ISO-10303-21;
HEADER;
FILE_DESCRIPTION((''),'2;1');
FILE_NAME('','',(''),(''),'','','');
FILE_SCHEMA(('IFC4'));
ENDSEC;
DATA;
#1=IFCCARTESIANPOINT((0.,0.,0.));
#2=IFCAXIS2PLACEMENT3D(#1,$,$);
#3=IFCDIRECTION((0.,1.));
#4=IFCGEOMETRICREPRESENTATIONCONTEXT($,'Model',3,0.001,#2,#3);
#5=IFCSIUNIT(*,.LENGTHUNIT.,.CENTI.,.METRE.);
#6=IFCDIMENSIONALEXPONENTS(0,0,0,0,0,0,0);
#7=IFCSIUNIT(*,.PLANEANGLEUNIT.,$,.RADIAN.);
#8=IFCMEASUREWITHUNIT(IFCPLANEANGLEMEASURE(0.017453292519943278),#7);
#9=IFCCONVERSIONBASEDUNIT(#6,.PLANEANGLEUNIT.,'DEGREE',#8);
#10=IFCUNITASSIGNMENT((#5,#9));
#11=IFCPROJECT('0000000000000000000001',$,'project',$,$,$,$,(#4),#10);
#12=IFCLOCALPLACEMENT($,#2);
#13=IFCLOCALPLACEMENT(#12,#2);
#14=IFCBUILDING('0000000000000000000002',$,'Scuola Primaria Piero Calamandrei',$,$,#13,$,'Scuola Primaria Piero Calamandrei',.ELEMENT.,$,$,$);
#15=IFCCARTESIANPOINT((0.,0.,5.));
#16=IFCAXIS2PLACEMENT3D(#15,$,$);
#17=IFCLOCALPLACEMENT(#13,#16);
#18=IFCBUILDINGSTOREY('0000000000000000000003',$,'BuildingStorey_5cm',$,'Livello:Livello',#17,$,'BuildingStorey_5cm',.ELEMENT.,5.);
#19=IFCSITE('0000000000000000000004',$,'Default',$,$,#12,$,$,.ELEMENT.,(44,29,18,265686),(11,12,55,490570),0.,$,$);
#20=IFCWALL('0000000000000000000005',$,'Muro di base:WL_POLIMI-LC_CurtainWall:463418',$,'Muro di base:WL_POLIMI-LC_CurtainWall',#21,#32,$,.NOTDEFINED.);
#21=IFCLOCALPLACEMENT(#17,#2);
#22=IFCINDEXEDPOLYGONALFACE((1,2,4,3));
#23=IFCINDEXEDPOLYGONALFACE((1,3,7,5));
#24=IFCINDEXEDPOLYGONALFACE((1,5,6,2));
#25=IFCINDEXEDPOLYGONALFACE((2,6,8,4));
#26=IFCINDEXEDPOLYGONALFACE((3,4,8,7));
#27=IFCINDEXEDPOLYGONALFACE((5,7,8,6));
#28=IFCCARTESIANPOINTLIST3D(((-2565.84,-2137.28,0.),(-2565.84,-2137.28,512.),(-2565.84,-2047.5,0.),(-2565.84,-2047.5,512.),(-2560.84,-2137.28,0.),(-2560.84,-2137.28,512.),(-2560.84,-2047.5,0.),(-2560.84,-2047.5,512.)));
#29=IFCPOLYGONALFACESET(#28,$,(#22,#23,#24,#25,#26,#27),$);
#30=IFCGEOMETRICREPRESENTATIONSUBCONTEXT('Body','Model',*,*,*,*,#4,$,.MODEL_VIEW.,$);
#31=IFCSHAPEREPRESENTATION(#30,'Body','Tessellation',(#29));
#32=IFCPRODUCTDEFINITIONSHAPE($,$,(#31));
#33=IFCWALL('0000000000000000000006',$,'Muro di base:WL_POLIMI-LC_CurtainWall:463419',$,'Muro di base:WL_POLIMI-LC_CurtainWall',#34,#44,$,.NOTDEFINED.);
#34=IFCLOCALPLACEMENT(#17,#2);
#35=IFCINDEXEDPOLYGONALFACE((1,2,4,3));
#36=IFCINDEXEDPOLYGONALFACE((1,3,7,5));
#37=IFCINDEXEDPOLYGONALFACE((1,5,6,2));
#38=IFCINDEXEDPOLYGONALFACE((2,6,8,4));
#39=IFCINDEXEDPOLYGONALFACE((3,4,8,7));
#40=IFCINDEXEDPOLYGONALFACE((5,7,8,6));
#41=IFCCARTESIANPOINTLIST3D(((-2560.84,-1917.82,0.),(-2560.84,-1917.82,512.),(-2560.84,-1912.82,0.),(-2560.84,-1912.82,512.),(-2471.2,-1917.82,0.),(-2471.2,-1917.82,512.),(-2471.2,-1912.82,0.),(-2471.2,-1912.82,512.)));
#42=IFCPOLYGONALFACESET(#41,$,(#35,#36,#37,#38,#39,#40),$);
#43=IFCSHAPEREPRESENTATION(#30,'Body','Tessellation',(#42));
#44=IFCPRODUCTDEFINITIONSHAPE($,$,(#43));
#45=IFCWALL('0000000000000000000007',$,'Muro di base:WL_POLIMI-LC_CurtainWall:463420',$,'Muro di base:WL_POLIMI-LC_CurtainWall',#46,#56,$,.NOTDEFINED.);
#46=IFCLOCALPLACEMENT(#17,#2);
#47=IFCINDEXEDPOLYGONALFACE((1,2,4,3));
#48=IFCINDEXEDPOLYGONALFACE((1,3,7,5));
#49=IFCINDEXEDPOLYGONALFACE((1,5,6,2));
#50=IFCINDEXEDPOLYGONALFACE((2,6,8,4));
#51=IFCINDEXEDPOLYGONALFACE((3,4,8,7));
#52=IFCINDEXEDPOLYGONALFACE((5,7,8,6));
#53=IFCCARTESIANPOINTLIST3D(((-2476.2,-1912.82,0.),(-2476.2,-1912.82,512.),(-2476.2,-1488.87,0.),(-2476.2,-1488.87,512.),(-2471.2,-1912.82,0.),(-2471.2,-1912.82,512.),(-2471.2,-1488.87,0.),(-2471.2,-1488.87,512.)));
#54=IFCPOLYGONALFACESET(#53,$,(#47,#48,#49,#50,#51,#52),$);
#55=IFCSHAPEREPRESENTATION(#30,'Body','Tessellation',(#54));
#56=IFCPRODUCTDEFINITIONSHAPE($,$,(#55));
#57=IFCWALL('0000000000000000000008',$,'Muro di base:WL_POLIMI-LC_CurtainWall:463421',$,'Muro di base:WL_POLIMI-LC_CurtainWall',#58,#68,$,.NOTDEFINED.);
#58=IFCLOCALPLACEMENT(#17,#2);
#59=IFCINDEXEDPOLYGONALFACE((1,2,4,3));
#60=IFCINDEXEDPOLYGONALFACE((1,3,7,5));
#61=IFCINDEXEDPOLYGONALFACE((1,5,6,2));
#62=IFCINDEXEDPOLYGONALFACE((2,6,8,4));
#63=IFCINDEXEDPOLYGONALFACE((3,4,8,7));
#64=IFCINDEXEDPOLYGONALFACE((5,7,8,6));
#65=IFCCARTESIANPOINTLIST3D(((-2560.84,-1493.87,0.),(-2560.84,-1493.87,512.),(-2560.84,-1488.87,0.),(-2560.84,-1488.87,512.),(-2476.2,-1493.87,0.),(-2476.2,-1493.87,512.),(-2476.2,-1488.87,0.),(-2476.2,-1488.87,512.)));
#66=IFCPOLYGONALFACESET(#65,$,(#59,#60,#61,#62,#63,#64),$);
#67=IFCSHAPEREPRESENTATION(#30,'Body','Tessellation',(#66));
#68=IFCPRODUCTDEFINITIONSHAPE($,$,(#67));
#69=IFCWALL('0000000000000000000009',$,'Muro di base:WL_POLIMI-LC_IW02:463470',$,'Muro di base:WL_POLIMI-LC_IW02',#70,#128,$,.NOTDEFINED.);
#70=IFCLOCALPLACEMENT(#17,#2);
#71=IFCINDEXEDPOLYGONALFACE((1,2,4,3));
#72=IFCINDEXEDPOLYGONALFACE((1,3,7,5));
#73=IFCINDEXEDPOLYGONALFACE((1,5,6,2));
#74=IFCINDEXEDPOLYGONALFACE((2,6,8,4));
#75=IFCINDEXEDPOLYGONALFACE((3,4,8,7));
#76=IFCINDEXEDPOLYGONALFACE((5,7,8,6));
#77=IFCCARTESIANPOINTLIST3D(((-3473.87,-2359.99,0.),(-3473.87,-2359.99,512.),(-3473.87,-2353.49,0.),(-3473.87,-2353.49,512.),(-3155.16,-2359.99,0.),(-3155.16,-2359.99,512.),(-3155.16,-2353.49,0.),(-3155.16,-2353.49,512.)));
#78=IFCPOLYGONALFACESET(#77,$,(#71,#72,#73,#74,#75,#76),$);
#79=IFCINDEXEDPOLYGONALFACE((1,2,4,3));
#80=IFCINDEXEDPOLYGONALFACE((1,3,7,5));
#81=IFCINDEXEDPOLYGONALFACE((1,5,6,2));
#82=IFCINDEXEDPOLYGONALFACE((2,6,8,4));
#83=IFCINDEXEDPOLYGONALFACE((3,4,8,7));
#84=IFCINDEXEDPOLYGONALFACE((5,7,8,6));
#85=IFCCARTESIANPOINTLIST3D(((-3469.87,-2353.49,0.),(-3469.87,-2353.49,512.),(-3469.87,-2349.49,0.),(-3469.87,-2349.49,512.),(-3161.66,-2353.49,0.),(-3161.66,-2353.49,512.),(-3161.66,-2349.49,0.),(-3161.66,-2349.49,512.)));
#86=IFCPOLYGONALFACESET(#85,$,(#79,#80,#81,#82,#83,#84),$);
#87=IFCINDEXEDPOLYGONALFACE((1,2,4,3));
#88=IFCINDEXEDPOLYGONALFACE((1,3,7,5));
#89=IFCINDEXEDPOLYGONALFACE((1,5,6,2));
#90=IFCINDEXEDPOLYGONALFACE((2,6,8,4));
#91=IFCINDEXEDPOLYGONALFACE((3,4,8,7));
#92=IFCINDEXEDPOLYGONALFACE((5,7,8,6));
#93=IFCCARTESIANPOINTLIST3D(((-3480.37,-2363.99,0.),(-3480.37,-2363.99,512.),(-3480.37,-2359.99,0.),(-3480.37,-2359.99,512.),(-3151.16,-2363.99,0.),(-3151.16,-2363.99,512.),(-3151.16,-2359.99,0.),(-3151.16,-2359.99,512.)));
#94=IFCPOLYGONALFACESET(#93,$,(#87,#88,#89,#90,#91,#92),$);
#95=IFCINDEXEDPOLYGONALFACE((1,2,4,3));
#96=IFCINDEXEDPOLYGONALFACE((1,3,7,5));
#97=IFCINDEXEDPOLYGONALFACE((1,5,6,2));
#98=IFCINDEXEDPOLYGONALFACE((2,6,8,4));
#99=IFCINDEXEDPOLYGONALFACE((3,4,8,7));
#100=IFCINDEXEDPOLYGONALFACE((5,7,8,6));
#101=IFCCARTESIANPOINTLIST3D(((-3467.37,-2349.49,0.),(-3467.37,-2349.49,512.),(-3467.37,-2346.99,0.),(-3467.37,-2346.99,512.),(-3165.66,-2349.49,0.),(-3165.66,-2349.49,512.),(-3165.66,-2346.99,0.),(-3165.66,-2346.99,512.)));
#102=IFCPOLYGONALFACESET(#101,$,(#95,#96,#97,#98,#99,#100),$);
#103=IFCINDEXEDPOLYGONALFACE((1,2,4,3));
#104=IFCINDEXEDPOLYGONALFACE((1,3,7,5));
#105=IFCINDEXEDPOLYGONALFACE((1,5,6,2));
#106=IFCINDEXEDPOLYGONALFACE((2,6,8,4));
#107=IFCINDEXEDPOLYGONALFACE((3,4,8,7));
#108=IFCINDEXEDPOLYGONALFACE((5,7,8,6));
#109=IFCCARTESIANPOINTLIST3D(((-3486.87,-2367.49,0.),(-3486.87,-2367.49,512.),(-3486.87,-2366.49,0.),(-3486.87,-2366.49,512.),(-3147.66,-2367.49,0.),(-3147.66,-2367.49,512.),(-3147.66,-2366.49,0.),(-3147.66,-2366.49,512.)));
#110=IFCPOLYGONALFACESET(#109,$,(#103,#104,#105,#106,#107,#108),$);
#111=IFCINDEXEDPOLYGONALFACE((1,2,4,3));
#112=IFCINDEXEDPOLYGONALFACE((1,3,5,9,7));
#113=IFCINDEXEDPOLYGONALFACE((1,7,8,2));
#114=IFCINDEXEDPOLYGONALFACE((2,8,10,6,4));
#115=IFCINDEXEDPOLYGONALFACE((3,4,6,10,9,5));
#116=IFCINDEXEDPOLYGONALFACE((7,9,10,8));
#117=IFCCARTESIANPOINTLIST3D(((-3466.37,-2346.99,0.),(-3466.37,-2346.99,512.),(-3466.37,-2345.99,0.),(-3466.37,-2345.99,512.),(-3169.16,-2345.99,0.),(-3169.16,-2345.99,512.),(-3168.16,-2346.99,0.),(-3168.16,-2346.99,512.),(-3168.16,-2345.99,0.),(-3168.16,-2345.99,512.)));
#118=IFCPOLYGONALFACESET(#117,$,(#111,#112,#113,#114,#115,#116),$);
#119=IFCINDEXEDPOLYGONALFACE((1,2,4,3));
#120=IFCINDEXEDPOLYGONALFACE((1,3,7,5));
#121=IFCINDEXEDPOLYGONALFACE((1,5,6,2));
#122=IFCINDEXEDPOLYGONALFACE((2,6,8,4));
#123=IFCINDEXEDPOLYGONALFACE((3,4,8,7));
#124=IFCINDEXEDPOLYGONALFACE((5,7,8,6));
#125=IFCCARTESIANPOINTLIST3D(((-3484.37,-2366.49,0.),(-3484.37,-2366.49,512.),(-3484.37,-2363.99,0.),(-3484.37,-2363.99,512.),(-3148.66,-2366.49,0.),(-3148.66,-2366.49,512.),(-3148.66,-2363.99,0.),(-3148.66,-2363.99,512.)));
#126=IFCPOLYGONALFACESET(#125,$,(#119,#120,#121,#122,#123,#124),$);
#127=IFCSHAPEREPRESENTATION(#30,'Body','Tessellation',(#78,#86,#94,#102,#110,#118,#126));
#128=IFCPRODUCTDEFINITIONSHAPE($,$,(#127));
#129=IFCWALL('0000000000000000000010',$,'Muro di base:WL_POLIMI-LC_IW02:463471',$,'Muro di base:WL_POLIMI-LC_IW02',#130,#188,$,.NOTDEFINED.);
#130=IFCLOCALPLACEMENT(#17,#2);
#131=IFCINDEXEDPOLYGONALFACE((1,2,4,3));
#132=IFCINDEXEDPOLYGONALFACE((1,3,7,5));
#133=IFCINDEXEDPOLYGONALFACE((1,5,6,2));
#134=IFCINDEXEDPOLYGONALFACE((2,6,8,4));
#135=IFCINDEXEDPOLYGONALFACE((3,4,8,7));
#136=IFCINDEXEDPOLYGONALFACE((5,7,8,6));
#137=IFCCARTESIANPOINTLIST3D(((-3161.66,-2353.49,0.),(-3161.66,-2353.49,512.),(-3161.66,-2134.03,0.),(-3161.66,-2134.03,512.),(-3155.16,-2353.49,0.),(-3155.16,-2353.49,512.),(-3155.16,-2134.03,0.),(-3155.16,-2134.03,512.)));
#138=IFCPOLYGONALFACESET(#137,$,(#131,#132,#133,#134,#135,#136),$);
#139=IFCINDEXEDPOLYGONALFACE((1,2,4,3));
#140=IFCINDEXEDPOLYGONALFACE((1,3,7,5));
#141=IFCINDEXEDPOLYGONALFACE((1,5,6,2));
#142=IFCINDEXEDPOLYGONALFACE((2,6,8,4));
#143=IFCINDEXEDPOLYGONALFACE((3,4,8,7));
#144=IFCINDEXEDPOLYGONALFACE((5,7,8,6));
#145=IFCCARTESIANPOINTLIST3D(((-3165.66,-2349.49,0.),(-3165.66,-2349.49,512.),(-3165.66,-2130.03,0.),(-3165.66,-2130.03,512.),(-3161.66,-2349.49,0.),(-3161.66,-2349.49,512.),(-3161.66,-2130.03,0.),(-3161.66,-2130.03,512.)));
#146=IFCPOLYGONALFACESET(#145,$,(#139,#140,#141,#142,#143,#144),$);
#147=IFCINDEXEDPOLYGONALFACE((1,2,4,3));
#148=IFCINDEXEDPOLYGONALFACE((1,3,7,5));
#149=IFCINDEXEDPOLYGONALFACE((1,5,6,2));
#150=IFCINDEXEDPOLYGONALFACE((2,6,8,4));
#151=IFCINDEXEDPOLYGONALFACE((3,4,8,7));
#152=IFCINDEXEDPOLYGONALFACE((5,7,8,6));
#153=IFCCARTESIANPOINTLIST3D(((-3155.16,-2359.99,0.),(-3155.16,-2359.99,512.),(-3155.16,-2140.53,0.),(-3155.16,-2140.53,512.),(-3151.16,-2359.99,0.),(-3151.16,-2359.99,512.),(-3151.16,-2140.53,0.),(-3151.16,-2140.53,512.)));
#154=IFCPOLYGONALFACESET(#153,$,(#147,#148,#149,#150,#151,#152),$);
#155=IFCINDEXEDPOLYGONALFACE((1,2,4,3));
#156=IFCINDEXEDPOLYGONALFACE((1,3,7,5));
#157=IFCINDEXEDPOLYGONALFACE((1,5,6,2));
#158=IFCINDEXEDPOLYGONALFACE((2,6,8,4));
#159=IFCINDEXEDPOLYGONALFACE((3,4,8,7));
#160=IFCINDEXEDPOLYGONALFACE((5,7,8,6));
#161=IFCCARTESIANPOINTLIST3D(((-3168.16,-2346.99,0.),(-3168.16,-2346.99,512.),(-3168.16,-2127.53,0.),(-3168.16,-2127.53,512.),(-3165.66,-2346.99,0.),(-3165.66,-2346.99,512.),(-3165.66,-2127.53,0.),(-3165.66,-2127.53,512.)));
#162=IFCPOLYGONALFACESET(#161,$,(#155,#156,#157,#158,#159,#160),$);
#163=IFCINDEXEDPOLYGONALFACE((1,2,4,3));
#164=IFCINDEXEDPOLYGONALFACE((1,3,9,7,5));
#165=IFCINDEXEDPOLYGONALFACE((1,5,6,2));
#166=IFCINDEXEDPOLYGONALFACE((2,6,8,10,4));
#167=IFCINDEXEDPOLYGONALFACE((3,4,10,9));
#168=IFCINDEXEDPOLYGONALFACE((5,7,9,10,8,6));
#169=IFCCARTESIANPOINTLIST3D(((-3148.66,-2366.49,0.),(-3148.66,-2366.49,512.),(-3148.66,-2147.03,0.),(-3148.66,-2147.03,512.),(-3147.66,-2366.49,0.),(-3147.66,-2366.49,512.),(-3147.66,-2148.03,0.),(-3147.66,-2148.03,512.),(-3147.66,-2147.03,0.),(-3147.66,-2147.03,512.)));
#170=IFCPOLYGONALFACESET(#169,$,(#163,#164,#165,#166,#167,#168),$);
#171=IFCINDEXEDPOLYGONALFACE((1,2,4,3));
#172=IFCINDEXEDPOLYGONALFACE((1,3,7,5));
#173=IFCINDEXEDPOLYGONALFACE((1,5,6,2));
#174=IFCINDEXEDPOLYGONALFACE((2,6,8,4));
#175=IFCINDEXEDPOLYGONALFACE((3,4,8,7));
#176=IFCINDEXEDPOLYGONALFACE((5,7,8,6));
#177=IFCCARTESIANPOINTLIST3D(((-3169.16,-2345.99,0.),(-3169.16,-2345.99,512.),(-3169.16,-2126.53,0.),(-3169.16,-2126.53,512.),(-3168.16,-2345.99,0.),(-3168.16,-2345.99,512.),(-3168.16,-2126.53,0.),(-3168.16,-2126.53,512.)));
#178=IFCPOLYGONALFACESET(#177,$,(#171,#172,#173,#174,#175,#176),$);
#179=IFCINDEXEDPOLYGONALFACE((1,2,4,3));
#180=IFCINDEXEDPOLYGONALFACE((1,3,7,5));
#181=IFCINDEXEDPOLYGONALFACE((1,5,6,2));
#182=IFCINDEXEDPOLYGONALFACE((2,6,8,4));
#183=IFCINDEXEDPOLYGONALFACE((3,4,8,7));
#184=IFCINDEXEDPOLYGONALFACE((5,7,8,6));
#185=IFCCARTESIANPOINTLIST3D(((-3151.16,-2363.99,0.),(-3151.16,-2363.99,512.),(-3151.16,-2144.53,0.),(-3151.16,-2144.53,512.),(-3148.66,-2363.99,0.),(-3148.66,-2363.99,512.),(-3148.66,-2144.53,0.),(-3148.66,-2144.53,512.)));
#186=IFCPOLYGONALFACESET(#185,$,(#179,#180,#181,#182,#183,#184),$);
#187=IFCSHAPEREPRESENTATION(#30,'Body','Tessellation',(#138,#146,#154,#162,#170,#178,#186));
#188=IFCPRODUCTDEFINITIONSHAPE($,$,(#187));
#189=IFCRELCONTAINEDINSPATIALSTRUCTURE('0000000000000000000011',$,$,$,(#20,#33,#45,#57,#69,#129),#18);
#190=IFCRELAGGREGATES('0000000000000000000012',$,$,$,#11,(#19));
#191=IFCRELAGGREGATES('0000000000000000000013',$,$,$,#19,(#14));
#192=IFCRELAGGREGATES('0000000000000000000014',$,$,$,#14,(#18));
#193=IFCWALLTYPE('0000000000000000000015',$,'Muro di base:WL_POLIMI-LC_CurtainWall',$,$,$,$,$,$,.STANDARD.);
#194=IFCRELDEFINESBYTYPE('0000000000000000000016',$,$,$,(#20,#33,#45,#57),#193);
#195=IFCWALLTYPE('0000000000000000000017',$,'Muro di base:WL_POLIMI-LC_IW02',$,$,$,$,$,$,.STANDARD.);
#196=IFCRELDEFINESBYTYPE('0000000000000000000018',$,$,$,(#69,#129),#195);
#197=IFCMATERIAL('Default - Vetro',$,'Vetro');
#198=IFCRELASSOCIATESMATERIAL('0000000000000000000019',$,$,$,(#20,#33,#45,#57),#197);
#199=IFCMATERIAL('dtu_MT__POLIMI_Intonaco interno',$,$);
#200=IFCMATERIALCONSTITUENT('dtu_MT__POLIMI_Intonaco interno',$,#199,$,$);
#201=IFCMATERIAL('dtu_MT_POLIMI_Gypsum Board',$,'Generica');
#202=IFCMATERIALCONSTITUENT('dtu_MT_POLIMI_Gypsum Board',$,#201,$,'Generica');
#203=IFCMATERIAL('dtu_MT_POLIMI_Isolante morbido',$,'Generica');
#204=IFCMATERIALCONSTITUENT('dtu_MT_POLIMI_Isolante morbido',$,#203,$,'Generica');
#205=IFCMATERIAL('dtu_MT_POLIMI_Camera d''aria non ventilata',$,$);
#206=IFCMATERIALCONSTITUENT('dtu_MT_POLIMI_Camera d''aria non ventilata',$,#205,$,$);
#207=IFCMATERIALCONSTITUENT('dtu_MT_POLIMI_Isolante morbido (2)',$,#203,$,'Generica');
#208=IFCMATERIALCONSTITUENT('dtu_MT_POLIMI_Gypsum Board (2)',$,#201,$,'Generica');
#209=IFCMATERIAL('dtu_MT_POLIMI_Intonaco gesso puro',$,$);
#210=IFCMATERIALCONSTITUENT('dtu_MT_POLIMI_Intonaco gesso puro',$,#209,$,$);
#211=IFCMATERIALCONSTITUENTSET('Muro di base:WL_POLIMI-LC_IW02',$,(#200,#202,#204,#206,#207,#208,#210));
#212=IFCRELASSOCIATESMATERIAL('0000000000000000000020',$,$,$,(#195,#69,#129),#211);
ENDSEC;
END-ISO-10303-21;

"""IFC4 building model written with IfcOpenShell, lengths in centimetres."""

from ifc_helpers import new_model, entity, si_unit, converted_unit, direction, frame, origin, place, context, subcontext, project, spatial, indexed_curve, outline, extrude, material, constituent, constituent_set, type_object, element, save


model = new_model("IFC4")

# Units and contexts
model_context = context("Model", 3, precision=0.001, world=origin(), true_north=direction((0.0, 1.0)))
body_context = subcontext(model_context, "Body", "Model", "MODEL_VIEW")
ifc_project = project(units=[si_unit("LENGTHUNIT", "METRE", prefix="CENTI"), converted_unit("PLANEANGLEUNIT", "DEGREE", entity("IfcPlaneAngleMeasure", 0.017453292519943278), si_unit("PLANEANGLEUNIT", "RADIAN"), dimensions=[0, 0, 0, 0, 0, 0, 0])], contexts=[model_context])

# Site, building, storey
site_placement = place(None, origin())
site = spatial("IfcSite", under=ifc_project, at=site_placement, Name="Default", CompositionType="ELEMENT", RefLatitude=(44, 29, 18, 265686), RefLongitude=(11, 12, 55, 490570), RefElevation=0.0)
building_placement = place(site_placement, origin())
building = spatial("IfcBuilding", under=site, at=building_placement, Name="Scuola Primaria Piero Calamandrei", LongName="Scuola Primaria Piero Calamandrei", CompositionType="ELEMENT")
storey_placement = place(building_placement, frame((0.0, 0.0, 5.0)))
storey = spatial("IfcBuildingStorey", under=building, at=storey_placement, Name="BuildingStorey_5cm", ObjectType="Livello:Livello", LongName="BuildingStorey_5cm", CompositionType="ELEMENT", Elevation=5.0)

# Shared definitions
ifc_material_1 = material(Name="dtu_MT_POLIMI_Intonaco gesso puro")

# Walls
ifc_material_2 = material(Name="Default - Vetro", Category="Vetro")
wall_type_1 = type_object("IfcWallType", Name="Muro di base:WL_POLIMI-LC_CurtainWall", PredefinedType="STANDARD")
wall_1_placement = place(storey_placement, frame((-2563.34, -2047.5, 0.0), z_axis=(0.0, 0.0, 1.0), x_axis=(0.0, -1.0, 0.0)))
element("IfcWall", 1, at=wall_1_placement, inside=storey, type_object=wall_type_1, material=ifc_material_2, Name="Muro di base:WL_POLIMI-LC_CurtainWall:463418", ObjectType="Muro di base:WL_POLIMI-LC_CurtainWall", PredefinedType="NOTDEFINED", context=body_context, shape_type="SweptSolid", body=[
    extrude(outline(indexed_curve([(89.78, 2.5), (0.0, 2.5), (0.0, -2.5), (89.78, -2.5), (89.78, 2.5)], self_intersect=False)), origin(), (0.0, 0.0, 1.0), 512.0),
])
wall_2_placement = place(storey_placement, frame((-2471.2, -1915.32, 0.0), z_axis=(0.0, 0.0, 1.0), x_axis=(-1.0, 0.0, 0.0)))
element("IfcWall", 2, at=wall_2_placement, inside=storey, type_object=wall_type_1, material=ifc_material_2, Name="Muro di base:WL_POLIMI-LC_CurtainWall:463419", ObjectType="Muro di base:WL_POLIMI-LC_CurtainWall", PredefinedType="NOTDEFINED", context=body_context, shape_type="SweptSolid", body=[
    extrude(outline(indexed_curve([(89.64, 2.5), (0.0, 2.5), (0.0, -2.5), (89.64, -2.5), (89.64, 2.5)], self_intersect=False)), origin(), (0.0, 0.0, 1.0), 512.0),
])
wall_3_placement = place(storey_placement, frame((-2473.7, -1488.87, 0.0), z_axis=(0.0, 0.0, 1.0), x_axis=(0.0, -1.0, 0.0)))
element("IfcWall", 3, at=wall_3_placement, inside=storey, type_object=wall_type_1, material=ifc_material_2, Name="Muro di base:WL_POLIMI-LC_CurtainWall:463420", ObjectType="Muro di base:WL_POLIMI-LC_CurtainWall", PredefinedType="NOTDEFINED", context=body_context, shape_type="SweptSolid", body=[
    extrude(outline(indexed_curve([(423.95, 2.5), (0.0, 2.5), (0.0, -2.5), (423.95, -2.5), (423.95, 2.5)], self_intersect=False)), origin(), (0.0, 0.0, 1.0), 512.0),
])
wall_4_placement = place(storey_placement, frame((-2560.84, -1491.37, 0.0)))
element("IfcWall", 4, at=wall_4_placement, inside=storey, type_object=wall_type_1, material=ifc_material_2, Name="Muro di base:WL_POLIMI-LC_CurtainWall:463421", ObjectType="Muro di base:WL_POLIMI-LC_CurtainWall", PredefinedType="NOTDEFINED", context=body_context, shape_type="SweptSolid", body=[
    extrude(outline(indexed_curve([(84.64, 2.5), (0.0, 2.5), (0.0, -2.5), (84.64, -2.5), (84.64, 2.5)], self_intersect=False)), origin(), (0.0, 0.0, 1.0), 512.0),
])

# Shared definitions
ifc_material_3 = material(Name="dtu_MT__POLIMI_Intonaco interno")

# Walls
ifc_constituent_1 = constituent(ifc_material_3, Name="dtu_MT__POLIMI_Intonaco interno")
ifc_material_4 = material(Name="dtu_MT_POLIMI_Gypsum Board", Category="Generica")
ifc_constituent_2 = constituent(ifc_material_4, Name="dtu_MT_POLIMI_Gypsum Board", Category="Generica")
ifc_material_5 = material(Name="dtu_MT_POLIMI_Isolante morbido", Category="Generica")
ifc_constituent_3 = constituent(ifc_material_5, Name="dtu_MT_POLIMI_Isolante morbido", Category="Generica")
ifc_material_6 = material(Name="dtu_MT_POLIMI_Camera d'aria non ventilata")
ifc_constituent_4 = constituent(ifc_material_6, Name="dtu_MT_POLIMI_Camera d'aria non ventilata")
ifc_constituent_5 = constituent(ifc_material_5, Name="dtu_MT_POLIMI_Isolante morbido (2)", Category="Generica")
ifc_constituent_6 = constituent(ifc_material_4, Name="dtu_MT_POLIMI_Gypsum Board (2)", Category="Generica")
ifc_constituent_7 = constituent(ifc_material_1, Name="dtu_MT_POLIMI_Intonaco gesso puro")
ifc_constituent_set_1 = constituent_set(constituents=[ifc_constituent_1, ifc_constituent_2, ifc_constituent_3, ifc_constituent_4, ifc_constituent_5, ifc_constituent_6, ifc_constituent_7], Name="Muro di base:WL_POLIMI-LC_IW02")
wall_type_2 = type_object("IfcWallType", Name="Muro di base:WL_POLIMI-LC_IW02", PredefinedType="STANDARD", material=ifc_constituent_set_1)
wall_5_placement = place(storey_placement, frame((-3466.37, -2356.74, 0.0)))
element("IfcWall", 5, at=wall_5_placement, inside=storey, type_object=wall_type_2, material=ifc_constituent_set_1, Name="Muro di base:WL_POLIMI-LC_IW02:463470", ObjectType="Muro di base:WL_POLIMI-LC_IW02", PredefinedType="NOTDEFINED", context=body_context, shape_type="SweptSolid", body=[
    extrude(outline(indexed_curve([(-159.35, -3.25), (159.35, -3.25), (159.35, 3.25), (-159.35, 3.25), (-159.35, -3.25)], self_intersect=False)), frame((151.85, 0.0, 0.0)), (0.0, 0.0, 1.0), 512.0),
    extrude(outline(indexed_curve([(-154.1, -2.0), (154.1, -2.0), (154.1, 2.0), (-154.1, 2.0), (-154.1, -2.0)], self_intersect=False)), frame((150.6, 5.25, 0.0)), (0.0, 0.0, 1.0), 512.0),
    extrude(outline(indexed_curve([(-164.6, -2.0), (164.6, -2.0), (164.6, 2.0), (-164.6, 2.0), (-164.6, -2.0)], self_intersect=False)), frame((150.6, -5.25, 0.0)), (0.0, 0.0, 1.0), 512.0),
    extrude(outline(indexed_curve([(-150.85, -1.25), (150.85, -1.25), (150.85, 1.25), (-150.85, 1.25), (-150.85, -1.25)], self_intersect=False)), frame((149.85, 8.5, 0.0)), (0.0, 0.0, 1.0), 512.0),
    extrude(outline(indexed_curve([(-0.5, -169.6), (0.5, -169.6), (0.5, 169.6), (-0.5, 169.6), (-0.5, -169.6)], self_intersect=False)), frame((149.1, -10.25, 0.0), z_axis=(0.0, 0.0, 1.0), x_axis=(0.0, 1.0, 0.0)), (0.0, 0.0, 1.0), 512.0),
    extrude(outline(indexed_curve([(-118.48, -0.4), (178.72, -0.4), (178.72, 0.6), (-119.48, 0.6), (-119.48, -0.4), (-118.48, -0.4)], self_intersect=False)), frame((178.72, 10.35, 0.0), z_axis=(0.0, 0.0, 1.0), x_axis=(-1.0, 0.0, 0.0)), (0.0, 0.0, 1.0), 512.0),
    extrude(outline(indexed_curve([(-167.85, -1.25), (167.85, -1.25), (167.85, 1.25), (-167.85, 1.25), (-167.85, -1.25)], self_intersect=False)), frame((149.85, -8.5, 0.0)), (0.0, 0.0, 1.0), 512.0),
])
wall_6_placement = place(storey_placement, frame((-3158.41, -2345.99, 0.0), z_axis=(0.0, 0.0, 1.0), x_axis=(0.0, 1.0, 0.0)))
element("IfcWall", 6, at=wall_6_placement, inside=storey, type_object=wall_type_2, material=ifc_constituent_set_1, Name="Muro di base:WL_POLIMI-LC_IW02:463471", ObjectType="Muro di base:WL_POLIMI-LC_IW02", PredefinedType="NOTDEFINED", context=body_context, shape_type="SweptSolid", body=[
    extrude(outline(indexed_curve([(-109.73, -3.25), (109.73, -3.25), (109.73, 3.25), (-109.73, 3.25), (-109.73, -3.25)], self_intersect=False)), frame((102.23, 0.0, 0.0)), (0.0, 0.0, 1.0), 512.0),
    extrude(outline(indexed_curve([(-109.73, -2.0), (109.73, -2.0), (109.73, 2.0), (-109.73, 2.0), (-109.73, -2.0)], self_intersect=False)), frame((106.23, 5.25, 0.0)), (0.0, 0.0, 1.0), 512.0),
    extrude(outline(indexed_curve([(-109.73, -2.0), (109.73, -2.0), (109.73, 2.0), (-109.73, 2.0), (-109.73, -2.0)], self_intersect=False)), frame((95.73, -5.25, 0.0)), (0.0, 0.0, 1.0), 512.0),
    extrude(outline(indexed_curve([(-109.73, -1.25), (109.73, -1.25), (109.73, 1.25), (-109.73, 1.25), (-109.73, -1.25)], self_intersect=False)), frame((108.73, 8.5, 0.0)), (0.0, 0.0, 1.0), 512.0),
    extrude(outline(indexed_curve([(86.98, -0.4), (87.98, -0.4), (87.98, 0.6), (-131.48, 0.6), (-131.48, -0.4), (86.98, -0.4)], self_intersect=False)), frame((110.98, -10.35, 0.0)), (0.0, 0.0, 1.0), 512.0),
    extrude(outline(indexed_curve([(-0.5, -109.73), (0.5, -109.73), (0.5, 109.73), (-0.5, 109.73), (-0.5, -109.73)], self_intersect=False)), frame((109.73, 10.25, 0.0), z_axis=(0.0, 0.0, 1.0), x_axis=(0.0, -1.0, 0.0)), (0.0, 0.0, 1.0), 512.0),
    extrude(outline(indexed_curve([(-109.73, -1.25), (109.73, -1.25), (109.73, 1.25), (-109.73, 1.25), (-109.73, -1.25)], self_intersect=False)), frame((91.73, -8.5, 0.0)), (0.0, 0.0, 1.0), 512.0),
])

save(model, "model.ifc")
